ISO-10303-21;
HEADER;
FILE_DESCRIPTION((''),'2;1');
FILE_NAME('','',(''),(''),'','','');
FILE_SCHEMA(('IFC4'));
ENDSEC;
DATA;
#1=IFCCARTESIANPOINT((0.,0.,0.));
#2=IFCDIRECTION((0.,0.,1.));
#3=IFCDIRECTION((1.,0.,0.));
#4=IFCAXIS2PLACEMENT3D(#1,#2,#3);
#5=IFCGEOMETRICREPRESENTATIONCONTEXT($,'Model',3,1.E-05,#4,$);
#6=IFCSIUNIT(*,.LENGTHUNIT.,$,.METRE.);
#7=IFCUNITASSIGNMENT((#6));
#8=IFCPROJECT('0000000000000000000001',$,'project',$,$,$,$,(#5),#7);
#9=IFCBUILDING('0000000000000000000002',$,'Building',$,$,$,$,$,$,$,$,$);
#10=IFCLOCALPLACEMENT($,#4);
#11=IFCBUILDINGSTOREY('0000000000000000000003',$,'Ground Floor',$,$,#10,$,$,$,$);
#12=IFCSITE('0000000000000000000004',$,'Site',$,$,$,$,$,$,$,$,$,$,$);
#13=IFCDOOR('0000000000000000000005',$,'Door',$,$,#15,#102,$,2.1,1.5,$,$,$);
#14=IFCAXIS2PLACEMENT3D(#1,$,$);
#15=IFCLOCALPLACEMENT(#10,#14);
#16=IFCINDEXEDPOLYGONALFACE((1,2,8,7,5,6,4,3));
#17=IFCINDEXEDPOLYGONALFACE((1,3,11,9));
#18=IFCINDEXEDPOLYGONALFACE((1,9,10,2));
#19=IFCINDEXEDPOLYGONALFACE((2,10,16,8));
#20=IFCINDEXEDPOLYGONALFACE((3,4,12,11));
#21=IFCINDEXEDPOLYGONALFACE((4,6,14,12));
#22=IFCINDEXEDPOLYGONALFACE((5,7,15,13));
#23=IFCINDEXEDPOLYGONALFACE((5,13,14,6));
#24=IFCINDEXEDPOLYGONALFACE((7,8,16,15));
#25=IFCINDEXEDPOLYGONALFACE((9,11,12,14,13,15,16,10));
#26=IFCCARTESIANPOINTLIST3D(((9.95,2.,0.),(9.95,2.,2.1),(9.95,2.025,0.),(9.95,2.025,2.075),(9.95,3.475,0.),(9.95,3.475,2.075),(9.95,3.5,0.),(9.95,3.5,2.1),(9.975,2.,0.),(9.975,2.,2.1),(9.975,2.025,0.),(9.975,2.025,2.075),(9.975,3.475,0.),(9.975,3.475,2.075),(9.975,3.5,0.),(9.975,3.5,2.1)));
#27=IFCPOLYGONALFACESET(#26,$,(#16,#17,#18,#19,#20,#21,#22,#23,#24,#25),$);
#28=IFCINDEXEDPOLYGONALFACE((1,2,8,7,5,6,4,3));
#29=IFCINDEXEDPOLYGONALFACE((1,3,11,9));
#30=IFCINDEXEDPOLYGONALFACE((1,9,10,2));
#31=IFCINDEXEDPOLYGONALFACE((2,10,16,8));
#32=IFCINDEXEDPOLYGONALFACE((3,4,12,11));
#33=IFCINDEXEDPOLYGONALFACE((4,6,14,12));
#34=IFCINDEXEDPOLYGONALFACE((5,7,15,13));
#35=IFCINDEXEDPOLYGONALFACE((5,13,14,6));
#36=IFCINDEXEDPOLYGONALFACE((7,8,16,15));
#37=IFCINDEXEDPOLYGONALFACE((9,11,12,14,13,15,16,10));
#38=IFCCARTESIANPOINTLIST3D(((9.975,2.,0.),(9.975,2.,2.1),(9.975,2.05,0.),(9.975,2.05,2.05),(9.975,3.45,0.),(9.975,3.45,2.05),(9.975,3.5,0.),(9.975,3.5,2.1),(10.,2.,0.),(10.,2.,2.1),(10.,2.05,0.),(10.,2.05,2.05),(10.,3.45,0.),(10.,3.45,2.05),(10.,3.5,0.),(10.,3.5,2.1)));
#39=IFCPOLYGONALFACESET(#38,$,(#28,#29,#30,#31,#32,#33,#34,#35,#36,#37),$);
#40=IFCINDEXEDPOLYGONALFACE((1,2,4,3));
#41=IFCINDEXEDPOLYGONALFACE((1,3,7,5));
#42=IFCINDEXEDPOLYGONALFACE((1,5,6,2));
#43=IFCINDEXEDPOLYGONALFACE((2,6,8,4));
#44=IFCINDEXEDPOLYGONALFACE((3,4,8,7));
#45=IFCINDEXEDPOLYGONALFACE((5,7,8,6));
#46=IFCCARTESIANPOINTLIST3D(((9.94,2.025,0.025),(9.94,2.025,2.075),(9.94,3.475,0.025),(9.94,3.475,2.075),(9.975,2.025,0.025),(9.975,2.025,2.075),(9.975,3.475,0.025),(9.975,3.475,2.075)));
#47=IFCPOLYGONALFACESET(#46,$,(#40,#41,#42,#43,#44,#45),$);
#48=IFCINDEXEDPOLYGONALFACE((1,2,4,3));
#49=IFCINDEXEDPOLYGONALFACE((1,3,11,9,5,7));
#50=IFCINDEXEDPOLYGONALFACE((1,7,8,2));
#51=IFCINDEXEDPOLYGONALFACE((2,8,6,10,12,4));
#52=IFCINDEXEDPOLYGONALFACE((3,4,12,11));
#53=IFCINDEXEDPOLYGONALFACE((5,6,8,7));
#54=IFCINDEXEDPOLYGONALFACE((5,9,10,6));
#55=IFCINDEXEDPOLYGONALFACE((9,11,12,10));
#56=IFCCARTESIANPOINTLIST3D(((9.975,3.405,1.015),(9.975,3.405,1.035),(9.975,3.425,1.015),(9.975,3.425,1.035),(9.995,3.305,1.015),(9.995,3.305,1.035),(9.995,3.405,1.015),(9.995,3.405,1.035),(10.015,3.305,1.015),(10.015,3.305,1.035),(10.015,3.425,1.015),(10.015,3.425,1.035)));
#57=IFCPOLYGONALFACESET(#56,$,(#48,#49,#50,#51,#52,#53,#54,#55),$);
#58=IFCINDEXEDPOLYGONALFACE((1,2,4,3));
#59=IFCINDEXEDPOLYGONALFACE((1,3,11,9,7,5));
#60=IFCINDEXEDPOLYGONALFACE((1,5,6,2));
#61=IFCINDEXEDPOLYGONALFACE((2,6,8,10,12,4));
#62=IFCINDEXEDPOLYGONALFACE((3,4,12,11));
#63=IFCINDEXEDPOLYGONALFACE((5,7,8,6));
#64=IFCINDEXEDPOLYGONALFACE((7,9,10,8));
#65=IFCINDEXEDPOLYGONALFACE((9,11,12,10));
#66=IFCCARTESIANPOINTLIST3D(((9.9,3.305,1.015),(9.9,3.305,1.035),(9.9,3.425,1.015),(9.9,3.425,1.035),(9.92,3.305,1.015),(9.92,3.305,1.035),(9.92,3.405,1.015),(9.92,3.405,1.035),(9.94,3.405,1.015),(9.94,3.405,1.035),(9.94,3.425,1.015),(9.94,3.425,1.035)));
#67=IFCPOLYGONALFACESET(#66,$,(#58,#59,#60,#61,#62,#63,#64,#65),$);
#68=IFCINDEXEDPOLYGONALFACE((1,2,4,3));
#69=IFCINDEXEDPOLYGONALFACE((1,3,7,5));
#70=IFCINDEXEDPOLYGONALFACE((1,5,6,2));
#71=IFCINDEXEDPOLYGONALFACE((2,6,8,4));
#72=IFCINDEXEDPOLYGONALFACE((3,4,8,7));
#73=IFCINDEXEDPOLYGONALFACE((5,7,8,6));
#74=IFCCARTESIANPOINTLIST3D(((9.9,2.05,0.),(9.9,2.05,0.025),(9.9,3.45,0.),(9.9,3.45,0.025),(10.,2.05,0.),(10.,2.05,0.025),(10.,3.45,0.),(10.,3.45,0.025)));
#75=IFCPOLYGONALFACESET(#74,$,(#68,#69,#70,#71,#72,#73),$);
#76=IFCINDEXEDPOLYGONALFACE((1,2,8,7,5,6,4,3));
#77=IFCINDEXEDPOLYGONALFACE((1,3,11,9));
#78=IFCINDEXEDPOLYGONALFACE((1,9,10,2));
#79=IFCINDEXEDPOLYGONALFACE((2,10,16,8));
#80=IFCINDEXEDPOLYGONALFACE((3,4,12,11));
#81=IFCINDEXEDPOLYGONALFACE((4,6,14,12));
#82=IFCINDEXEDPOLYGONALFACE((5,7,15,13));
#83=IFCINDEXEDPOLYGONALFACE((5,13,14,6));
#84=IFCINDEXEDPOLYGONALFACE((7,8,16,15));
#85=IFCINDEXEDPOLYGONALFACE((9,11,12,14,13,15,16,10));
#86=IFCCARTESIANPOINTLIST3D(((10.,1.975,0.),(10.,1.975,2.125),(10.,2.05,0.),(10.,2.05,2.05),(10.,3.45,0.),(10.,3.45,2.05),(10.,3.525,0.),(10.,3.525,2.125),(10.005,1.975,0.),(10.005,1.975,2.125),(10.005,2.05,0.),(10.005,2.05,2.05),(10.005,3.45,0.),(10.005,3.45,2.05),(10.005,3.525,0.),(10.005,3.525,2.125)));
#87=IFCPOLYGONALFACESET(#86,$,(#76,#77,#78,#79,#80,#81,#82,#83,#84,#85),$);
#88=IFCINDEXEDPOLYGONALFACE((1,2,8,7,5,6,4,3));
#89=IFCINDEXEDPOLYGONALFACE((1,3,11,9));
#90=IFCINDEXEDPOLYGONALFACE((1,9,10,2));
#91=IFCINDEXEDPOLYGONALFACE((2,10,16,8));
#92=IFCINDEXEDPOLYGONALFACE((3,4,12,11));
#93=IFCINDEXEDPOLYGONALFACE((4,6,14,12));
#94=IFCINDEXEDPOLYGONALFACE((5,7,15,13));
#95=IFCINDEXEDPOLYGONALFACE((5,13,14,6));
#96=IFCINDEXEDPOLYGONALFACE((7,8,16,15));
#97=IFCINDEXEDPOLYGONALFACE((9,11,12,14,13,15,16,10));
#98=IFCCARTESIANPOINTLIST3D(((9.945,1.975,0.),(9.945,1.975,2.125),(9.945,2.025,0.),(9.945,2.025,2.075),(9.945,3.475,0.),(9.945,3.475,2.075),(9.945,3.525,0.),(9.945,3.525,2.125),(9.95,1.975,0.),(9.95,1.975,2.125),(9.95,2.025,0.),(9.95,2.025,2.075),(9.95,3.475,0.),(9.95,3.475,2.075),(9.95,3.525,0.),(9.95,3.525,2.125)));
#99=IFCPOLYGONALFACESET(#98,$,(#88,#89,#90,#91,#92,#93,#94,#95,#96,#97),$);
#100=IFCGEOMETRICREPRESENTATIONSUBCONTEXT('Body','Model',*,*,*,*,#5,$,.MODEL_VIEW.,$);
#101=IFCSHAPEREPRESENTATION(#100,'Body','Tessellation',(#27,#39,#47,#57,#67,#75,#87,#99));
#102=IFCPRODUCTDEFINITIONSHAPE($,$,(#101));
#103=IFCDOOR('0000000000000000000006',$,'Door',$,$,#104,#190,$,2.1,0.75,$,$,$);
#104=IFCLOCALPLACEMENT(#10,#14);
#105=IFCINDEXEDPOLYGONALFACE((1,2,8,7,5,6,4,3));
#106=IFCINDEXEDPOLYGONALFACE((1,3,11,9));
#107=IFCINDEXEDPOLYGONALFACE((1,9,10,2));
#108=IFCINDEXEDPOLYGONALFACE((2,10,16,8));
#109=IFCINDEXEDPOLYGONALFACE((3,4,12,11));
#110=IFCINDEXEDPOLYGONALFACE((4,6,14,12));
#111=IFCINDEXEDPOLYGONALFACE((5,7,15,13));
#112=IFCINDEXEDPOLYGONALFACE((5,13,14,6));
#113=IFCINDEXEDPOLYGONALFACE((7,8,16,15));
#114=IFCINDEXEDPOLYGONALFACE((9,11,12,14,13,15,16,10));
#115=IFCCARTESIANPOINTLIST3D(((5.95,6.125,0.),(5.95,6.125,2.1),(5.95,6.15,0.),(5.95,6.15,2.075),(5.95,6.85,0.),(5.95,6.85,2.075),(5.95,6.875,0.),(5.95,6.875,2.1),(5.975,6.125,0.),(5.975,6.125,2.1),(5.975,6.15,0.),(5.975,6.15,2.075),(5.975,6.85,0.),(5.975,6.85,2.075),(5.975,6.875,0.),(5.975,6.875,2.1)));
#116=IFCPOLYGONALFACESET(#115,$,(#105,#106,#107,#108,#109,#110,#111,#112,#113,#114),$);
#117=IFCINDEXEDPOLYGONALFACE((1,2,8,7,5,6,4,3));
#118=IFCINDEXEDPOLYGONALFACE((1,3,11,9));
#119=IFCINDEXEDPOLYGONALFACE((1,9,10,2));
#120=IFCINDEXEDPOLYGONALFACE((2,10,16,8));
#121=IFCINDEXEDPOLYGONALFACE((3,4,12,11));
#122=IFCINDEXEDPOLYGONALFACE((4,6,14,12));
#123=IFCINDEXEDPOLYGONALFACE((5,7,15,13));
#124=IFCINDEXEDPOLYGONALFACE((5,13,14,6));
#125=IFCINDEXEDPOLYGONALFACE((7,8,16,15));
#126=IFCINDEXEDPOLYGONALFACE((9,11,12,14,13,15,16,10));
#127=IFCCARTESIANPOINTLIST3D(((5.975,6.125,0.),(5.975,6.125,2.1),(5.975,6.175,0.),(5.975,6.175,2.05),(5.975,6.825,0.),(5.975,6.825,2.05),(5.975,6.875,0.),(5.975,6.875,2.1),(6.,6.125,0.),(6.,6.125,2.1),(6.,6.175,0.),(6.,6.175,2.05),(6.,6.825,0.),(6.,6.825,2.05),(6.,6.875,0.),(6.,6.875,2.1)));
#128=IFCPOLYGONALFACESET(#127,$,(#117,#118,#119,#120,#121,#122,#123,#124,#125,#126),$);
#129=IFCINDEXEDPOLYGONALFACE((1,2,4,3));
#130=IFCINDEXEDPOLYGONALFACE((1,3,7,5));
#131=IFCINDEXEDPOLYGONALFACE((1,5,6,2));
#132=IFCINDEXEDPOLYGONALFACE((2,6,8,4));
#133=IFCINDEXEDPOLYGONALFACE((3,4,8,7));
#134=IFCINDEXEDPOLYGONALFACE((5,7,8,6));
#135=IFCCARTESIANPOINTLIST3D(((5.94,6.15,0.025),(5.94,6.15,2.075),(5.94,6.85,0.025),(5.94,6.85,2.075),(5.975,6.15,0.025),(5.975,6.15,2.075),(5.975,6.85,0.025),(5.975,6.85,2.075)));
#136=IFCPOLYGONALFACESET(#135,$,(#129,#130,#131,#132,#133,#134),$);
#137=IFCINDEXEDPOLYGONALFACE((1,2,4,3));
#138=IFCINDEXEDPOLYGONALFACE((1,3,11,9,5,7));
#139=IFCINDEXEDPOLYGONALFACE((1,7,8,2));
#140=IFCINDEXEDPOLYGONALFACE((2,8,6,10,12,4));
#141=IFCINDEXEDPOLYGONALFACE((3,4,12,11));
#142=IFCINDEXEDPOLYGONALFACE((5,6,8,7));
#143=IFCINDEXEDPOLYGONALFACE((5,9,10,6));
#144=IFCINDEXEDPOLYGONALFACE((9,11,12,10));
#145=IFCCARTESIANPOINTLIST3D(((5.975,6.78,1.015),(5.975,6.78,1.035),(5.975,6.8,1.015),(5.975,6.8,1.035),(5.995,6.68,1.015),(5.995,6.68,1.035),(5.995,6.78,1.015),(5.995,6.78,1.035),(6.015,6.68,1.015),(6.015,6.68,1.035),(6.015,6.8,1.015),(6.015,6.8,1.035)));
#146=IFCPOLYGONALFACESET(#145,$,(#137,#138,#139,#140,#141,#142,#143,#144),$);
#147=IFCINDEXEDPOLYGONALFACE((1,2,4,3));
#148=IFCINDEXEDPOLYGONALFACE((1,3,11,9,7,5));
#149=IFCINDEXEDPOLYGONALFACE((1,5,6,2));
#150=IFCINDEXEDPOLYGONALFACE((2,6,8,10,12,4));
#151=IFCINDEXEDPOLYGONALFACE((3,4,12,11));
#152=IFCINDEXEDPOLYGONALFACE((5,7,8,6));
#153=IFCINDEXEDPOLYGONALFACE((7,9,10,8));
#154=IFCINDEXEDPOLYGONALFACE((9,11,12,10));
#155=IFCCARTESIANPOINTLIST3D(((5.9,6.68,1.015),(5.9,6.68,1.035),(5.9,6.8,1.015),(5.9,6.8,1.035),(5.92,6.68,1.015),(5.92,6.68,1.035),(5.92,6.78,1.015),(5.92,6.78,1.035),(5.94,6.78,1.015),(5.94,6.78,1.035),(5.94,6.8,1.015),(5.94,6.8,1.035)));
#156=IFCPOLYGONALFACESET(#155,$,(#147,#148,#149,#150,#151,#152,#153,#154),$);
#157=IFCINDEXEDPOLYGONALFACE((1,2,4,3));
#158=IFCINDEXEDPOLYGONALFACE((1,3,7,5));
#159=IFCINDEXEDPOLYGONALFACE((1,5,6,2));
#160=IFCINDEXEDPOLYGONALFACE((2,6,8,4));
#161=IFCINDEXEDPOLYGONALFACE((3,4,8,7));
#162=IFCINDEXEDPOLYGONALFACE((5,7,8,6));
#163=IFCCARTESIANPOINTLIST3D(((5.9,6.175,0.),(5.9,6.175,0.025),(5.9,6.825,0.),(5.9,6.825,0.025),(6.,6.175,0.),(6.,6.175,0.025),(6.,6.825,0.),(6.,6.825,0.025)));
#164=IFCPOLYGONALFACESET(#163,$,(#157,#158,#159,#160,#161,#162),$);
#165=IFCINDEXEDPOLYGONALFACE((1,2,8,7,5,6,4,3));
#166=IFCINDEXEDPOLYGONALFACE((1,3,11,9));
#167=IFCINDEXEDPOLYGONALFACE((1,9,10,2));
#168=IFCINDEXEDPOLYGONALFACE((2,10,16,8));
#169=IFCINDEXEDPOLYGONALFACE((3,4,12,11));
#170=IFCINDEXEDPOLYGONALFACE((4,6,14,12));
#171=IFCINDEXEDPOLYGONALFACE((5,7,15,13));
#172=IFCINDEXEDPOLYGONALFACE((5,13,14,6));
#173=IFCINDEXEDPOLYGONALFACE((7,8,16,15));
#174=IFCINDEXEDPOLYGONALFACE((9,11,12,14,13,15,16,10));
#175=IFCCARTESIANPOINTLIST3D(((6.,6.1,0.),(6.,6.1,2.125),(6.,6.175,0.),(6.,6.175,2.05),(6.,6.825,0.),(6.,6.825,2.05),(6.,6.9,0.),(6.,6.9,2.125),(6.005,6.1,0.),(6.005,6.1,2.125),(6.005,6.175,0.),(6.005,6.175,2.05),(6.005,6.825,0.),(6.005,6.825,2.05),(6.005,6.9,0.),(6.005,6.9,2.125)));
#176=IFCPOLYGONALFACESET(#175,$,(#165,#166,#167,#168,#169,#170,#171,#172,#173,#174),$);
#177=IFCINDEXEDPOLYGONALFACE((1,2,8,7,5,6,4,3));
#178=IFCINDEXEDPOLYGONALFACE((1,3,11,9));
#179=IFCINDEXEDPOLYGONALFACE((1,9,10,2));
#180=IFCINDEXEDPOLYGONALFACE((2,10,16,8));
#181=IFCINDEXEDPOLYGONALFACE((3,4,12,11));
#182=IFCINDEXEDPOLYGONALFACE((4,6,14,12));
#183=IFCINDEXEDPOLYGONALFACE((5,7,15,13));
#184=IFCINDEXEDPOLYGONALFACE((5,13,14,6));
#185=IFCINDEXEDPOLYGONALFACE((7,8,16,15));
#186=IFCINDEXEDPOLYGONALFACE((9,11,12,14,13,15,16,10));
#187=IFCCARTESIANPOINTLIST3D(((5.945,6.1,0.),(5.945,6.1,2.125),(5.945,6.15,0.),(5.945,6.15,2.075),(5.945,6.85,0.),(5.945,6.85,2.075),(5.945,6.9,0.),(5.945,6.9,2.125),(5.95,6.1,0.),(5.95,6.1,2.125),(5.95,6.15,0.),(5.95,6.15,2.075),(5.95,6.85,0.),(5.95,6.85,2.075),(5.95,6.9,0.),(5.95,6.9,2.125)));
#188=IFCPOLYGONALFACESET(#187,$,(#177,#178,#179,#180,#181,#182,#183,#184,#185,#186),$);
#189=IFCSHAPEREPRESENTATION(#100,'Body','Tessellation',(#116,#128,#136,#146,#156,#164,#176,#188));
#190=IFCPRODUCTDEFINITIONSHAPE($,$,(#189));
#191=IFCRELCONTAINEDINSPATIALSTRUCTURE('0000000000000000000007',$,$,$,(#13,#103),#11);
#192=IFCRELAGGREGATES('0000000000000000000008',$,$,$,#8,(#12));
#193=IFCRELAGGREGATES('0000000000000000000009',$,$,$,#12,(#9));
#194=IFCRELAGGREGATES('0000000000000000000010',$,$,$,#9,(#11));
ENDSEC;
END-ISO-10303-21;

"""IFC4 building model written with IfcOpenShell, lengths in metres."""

from ifc_helpers import new_model, si_unit, frame, origin_with_axes, place, context, subcontext, project, spatial, line, indexed_curve, outline, extrude, element, save


model = new_model("IFC4")

# Units and contexts
model_context = context("Model", 3, precision=1e-05, world=origin_with_axes())
body_context = subcontext(model_context, "Body", "Model", "MODEL_VIEW")
ifc_project = project(units=[si_unit("LENGTHUNIT", "METRE")], contexts=[model_context])

# Site, building, storey
site = spatial("IfcSite", under=ifc_project, Name="Site")
building = spatial("IfcBuilding", under=site, Name="Building")
storey_placement = place(None, origin_with_axes())
storey = spatial("IfcBuildingStorey", under=building, at=storey_placement, Name="Ground Floor")

# Doors
door_1_placement = place(storey_placement, frame((10.0, 2.0, 0.0), z_axis=(0.0, 0.0, 1.0), x_axis=(0.0, 1.0, 0.0)))
element("IfcDoor", 1, at=door_1_placement, inside=storey, Name="Door", OverallHeight=2.1, OverallWidth=1.5, context=body_context, shape_type="SweptSolid", body=[
    extrude(outline(indexed_curve([(0.0, 0.0), (0.0, 2.1), (1.5, 2.1), (1.5, 0.0), (1.475, 0.0), (1.475, 2.075), (0.025, 2.075), (0.025, 0.0)], segments=[line(1, 2, 3, 4, 5, 6, 7, 8, 1)])), frame((0.0, 0.025, 0.0), z_axis=(0.0, -1.0, 0.0), x_axis=(1.0, 0.0, 0.0)), (0.0, 0.0, -1.0), 0.025),
    extrude(outline(indexed_curve([(0.0, 0.0), (0.0, 2.1), (1.5, 2.1), (1.5, 0.0), (1.45, 0.0), (1.45, 2.05), (0.05, 2.05), (0.05, 0.0)], segments=[line(1, 2, 3, 4, 5, 6, 7, 8, 1)])), frame((0.0, 0.0, 0.0), z_axis=(0.0, -1.0, 0.0), x_axis=(1.0, 0.0, 0.0)), (0.0, 0.0, -1.0), 0.025),
    extrude(outline(indexed_curve([(0.0, 0.0), (1.45, 0.0), (1.45, 0.035), (0.0, 0.035)], segments=[line(1, 2, 3, 4, 1)])), frame((0.025, 0.025, 0.025), z_axis=(0.0, 0.0, 1.0), x_axis=(1.0, 0.0, 0.0)), (0.0, 0.0, 1.0), 2.05),
    extrude(outline(indexed_curve([(0.0, 0.0), (0.0, -0.04), (-0.12, -0.04), (-0.12, -0.02), (-0.02, -0.02), (-0.02, 0.0)], segments=[line(1, 2, 3, 4, 5, 6, 1)])), frame((1.425, 0.025, 1.015), z_axis=(0.0, 0.0, 1.0), x_axis=(1.0, 0.0, 0.0)), (0.0, 0.0, 1.0), 0.02),
    extrude(outline(indexed_curve([(0.0, 0.0), (0.0, 0.04), (-0.12, 0.04), (-0.12, 0.02), (-0.02, 0.02), (-0.02, 0.0)], segments=[line(1, 2, 3, 4, 5, 6, 1)])), frame((1.425, 0.06, 1.015), z_axis=(0.0, 0.0, 1.0), x_axis=(1.0, 0.0, 0.0)), (0.0, 0.0, 1.0), 0.02),
    extrude(outline(indexed_curve([(0.0, 0.0), (1.4, 0.0), (1.4, 0.1), (0.0, 0.1)], segments=[line(1, 2, 3, 4, 1)])), frame((0.05, 0.0, 0.0), z_axis=(0.0, 0.0, 1.0), x_axis=(1.0, 0.0, 0.0)), (0.0, 0.0, 1.0), 0.025),
    extrude(outline(indexed_curve([(0.0, 0.0), (0.0, 2.125), (1.55, 2.125), (1.55, 0.0), (1.475, 0.0), (1.475, 2.05), (0.075, 2.05), (0.075, 0.0)], segments=[line(1, 2, 3, 4, 5, 6, 7, 8, 1)])), frame((-0.025, -0.005, 0.0), z_axis=(0.0, -1.0, 0.0), x_axis=(1.0, 0.0, 0.0)), (0.0, 0.0, -1.0), 0.005),
    extrude(outline(indexed_curve([(0.0, 0.0), (0.0, 2.125), (1.55, 2.125), (1.55, 0.0), (1.5, 0.0), (1.5, 2.075), (0.05, 2.075), (0.05, 0.0)], segments=[line(1, 2, 3, 4, 5, 6, 7, 8, 1)])), frame((-0.025, 0.05, 0.0), z_axis=(0.0, -1.0, 0.0), x_axis=(1.0, 0.0, 0.0)), (0.0, 0.0, -1.0), 0.005),
])
door_2_placement = place(storey_placement, frame((6.0, 6.125, 0.0), z_axis=(0.0, 0.0, 1.0), x_axis=(0.0, 1.0, 0.0)))
element("IfcDoor", 2, at=door_2_placement, inside=storey, Name="Door", OverallHeight=2.1, OverallWidth=0.75, context=body_context, shape_type="SweptSolid", body=[
    extrude(outline(indexed_curve([(0.0, 0.0), (0.0, 2.1), (0.75, 2.1), (0.75, 0.0), (0.725, 0.0), (0.725, 2.075), (0.025, 2.075), (0.025, 0.0)], segments=[line(1, 2, 3, 4, 5, 6, 7, 8, 1)])), frame((0.0, 0.025, 0.0), z_axis=(0.0, -1.0, 0.0), x_axis=(1.0, 0.0, 0.0)), (0.0, 0.0, -1.0), 0.025),
    extrude(outline(indexed_curve([(0.0, 0.0), (0.0, 2.1), (0.75, 2.1), (0.75, 0.0), (0.7, 0.0), (0.7, 2.05), (0.05, 2.05), (0.05, 0.0)], segments=[line(1, 2, 3, 4, 5, 6, 7, 8, 1)])), frame((0.0, 0.0, 0.0), z_axis=(0.0, -1.0, 0.0), x_axis=(1.0, 0.0, 0.0)), (0.0, 0.0, -1.0), 0.025),
    extrude(outline(indexed_curve([(0.0, 0.0), (0.7, 0.0), (0.7, 0.035), (0.0, 0.035)], segments=[line(1, 2, 3, 4, 1)])), frame((0.025, 0.025, 0.025), z_axis=(0.0, 0.0, 1.0), x_axis=(1.0, 0.0, 0.0)), (0.0, 0.0, 1.0), 2.05),
    extrude(outline(indexed_curve([(0.0, 0.0), (0.0, -0.04), (-0.12, -0.04), (-0.12, -0.02), (-0.02, -0.02), (-0.02, 0.0)], segments=[line(1, 2, 3, 4, 5, 6, 1)])), frame((0.675, 0.025, 1.015), z_axis=(0.0, 0.0, 1.0), x_axis=(1.0, 0.0, 0.0)), (0.0, 0.0, 1.0), 0.02),
    extrude(outline(indexed_curve([(0.0, 0.0), (0.0, 0.04), (-0.12, 0.04), (-0.12, 0.02), (-0.02, 0.02), (-0.02, 0.0)], segments=[line(1, 2, 3, 4, 5, 6, 1)])), frame((0.675, 0.06, 1.015), z_axis=(0.0, 0.0, 1.0), x_axis=(1.0, 0.0, 0.0)), (0.0, 0.0, 1.0), 0.02),
    extrude(outline(indexed_curve([(0.0, 0.0), (0.65, 0.0), (0.65, 0.1), (0.0, 0.1)], segments=[line(1, 2, 3, 4, 1)])), frame((0.05, 0.0, 0.0), z_axis=(0.0, 0.0, 1.0), x_axis=(1.0, 0.0, 0.0)), (0.0, 0.0, 1.0), 0.025),
    extrude(outline(indexed_curve([(0.0, 0.0), (0.0, 2.125), (0.8, 2.125), (0.8, 0.0), (0.725, 0.0), (0.725, 2.05), (0.075, 2.05), (0.075, 0.0)], segments=[line(1, 2, 3, 4, 5, 6, 7, 8, 1)])), frame((-0.025, -0.005, 0.0), z_axis=(0.0, -1.0, 0.0), x_axis=(1.0, 0.0, 0.0)), (0.0, 0.0, -1.0), 0.005),
    extrude(outline(indexed_curve([(0.0, 0.0), (0.0, 2.125), (0.8, 2.125), (0.8, 0.0), (0.75, 0.0), (0.75, 2.075), (0.05, 2.075), (0.05, 0.0)], segments=[line(1, 2, 3, 4, 5, 6, 7, 8, 1)])), frame((-0.025, 0.05, 0.0), z_axis=(0.0, -1.0, 0.0), x_axis=(1.0, 0.0, 0.0)), (0.0, 0.0, -1.0), 0.005),
])

save(model, "model.ifc")
